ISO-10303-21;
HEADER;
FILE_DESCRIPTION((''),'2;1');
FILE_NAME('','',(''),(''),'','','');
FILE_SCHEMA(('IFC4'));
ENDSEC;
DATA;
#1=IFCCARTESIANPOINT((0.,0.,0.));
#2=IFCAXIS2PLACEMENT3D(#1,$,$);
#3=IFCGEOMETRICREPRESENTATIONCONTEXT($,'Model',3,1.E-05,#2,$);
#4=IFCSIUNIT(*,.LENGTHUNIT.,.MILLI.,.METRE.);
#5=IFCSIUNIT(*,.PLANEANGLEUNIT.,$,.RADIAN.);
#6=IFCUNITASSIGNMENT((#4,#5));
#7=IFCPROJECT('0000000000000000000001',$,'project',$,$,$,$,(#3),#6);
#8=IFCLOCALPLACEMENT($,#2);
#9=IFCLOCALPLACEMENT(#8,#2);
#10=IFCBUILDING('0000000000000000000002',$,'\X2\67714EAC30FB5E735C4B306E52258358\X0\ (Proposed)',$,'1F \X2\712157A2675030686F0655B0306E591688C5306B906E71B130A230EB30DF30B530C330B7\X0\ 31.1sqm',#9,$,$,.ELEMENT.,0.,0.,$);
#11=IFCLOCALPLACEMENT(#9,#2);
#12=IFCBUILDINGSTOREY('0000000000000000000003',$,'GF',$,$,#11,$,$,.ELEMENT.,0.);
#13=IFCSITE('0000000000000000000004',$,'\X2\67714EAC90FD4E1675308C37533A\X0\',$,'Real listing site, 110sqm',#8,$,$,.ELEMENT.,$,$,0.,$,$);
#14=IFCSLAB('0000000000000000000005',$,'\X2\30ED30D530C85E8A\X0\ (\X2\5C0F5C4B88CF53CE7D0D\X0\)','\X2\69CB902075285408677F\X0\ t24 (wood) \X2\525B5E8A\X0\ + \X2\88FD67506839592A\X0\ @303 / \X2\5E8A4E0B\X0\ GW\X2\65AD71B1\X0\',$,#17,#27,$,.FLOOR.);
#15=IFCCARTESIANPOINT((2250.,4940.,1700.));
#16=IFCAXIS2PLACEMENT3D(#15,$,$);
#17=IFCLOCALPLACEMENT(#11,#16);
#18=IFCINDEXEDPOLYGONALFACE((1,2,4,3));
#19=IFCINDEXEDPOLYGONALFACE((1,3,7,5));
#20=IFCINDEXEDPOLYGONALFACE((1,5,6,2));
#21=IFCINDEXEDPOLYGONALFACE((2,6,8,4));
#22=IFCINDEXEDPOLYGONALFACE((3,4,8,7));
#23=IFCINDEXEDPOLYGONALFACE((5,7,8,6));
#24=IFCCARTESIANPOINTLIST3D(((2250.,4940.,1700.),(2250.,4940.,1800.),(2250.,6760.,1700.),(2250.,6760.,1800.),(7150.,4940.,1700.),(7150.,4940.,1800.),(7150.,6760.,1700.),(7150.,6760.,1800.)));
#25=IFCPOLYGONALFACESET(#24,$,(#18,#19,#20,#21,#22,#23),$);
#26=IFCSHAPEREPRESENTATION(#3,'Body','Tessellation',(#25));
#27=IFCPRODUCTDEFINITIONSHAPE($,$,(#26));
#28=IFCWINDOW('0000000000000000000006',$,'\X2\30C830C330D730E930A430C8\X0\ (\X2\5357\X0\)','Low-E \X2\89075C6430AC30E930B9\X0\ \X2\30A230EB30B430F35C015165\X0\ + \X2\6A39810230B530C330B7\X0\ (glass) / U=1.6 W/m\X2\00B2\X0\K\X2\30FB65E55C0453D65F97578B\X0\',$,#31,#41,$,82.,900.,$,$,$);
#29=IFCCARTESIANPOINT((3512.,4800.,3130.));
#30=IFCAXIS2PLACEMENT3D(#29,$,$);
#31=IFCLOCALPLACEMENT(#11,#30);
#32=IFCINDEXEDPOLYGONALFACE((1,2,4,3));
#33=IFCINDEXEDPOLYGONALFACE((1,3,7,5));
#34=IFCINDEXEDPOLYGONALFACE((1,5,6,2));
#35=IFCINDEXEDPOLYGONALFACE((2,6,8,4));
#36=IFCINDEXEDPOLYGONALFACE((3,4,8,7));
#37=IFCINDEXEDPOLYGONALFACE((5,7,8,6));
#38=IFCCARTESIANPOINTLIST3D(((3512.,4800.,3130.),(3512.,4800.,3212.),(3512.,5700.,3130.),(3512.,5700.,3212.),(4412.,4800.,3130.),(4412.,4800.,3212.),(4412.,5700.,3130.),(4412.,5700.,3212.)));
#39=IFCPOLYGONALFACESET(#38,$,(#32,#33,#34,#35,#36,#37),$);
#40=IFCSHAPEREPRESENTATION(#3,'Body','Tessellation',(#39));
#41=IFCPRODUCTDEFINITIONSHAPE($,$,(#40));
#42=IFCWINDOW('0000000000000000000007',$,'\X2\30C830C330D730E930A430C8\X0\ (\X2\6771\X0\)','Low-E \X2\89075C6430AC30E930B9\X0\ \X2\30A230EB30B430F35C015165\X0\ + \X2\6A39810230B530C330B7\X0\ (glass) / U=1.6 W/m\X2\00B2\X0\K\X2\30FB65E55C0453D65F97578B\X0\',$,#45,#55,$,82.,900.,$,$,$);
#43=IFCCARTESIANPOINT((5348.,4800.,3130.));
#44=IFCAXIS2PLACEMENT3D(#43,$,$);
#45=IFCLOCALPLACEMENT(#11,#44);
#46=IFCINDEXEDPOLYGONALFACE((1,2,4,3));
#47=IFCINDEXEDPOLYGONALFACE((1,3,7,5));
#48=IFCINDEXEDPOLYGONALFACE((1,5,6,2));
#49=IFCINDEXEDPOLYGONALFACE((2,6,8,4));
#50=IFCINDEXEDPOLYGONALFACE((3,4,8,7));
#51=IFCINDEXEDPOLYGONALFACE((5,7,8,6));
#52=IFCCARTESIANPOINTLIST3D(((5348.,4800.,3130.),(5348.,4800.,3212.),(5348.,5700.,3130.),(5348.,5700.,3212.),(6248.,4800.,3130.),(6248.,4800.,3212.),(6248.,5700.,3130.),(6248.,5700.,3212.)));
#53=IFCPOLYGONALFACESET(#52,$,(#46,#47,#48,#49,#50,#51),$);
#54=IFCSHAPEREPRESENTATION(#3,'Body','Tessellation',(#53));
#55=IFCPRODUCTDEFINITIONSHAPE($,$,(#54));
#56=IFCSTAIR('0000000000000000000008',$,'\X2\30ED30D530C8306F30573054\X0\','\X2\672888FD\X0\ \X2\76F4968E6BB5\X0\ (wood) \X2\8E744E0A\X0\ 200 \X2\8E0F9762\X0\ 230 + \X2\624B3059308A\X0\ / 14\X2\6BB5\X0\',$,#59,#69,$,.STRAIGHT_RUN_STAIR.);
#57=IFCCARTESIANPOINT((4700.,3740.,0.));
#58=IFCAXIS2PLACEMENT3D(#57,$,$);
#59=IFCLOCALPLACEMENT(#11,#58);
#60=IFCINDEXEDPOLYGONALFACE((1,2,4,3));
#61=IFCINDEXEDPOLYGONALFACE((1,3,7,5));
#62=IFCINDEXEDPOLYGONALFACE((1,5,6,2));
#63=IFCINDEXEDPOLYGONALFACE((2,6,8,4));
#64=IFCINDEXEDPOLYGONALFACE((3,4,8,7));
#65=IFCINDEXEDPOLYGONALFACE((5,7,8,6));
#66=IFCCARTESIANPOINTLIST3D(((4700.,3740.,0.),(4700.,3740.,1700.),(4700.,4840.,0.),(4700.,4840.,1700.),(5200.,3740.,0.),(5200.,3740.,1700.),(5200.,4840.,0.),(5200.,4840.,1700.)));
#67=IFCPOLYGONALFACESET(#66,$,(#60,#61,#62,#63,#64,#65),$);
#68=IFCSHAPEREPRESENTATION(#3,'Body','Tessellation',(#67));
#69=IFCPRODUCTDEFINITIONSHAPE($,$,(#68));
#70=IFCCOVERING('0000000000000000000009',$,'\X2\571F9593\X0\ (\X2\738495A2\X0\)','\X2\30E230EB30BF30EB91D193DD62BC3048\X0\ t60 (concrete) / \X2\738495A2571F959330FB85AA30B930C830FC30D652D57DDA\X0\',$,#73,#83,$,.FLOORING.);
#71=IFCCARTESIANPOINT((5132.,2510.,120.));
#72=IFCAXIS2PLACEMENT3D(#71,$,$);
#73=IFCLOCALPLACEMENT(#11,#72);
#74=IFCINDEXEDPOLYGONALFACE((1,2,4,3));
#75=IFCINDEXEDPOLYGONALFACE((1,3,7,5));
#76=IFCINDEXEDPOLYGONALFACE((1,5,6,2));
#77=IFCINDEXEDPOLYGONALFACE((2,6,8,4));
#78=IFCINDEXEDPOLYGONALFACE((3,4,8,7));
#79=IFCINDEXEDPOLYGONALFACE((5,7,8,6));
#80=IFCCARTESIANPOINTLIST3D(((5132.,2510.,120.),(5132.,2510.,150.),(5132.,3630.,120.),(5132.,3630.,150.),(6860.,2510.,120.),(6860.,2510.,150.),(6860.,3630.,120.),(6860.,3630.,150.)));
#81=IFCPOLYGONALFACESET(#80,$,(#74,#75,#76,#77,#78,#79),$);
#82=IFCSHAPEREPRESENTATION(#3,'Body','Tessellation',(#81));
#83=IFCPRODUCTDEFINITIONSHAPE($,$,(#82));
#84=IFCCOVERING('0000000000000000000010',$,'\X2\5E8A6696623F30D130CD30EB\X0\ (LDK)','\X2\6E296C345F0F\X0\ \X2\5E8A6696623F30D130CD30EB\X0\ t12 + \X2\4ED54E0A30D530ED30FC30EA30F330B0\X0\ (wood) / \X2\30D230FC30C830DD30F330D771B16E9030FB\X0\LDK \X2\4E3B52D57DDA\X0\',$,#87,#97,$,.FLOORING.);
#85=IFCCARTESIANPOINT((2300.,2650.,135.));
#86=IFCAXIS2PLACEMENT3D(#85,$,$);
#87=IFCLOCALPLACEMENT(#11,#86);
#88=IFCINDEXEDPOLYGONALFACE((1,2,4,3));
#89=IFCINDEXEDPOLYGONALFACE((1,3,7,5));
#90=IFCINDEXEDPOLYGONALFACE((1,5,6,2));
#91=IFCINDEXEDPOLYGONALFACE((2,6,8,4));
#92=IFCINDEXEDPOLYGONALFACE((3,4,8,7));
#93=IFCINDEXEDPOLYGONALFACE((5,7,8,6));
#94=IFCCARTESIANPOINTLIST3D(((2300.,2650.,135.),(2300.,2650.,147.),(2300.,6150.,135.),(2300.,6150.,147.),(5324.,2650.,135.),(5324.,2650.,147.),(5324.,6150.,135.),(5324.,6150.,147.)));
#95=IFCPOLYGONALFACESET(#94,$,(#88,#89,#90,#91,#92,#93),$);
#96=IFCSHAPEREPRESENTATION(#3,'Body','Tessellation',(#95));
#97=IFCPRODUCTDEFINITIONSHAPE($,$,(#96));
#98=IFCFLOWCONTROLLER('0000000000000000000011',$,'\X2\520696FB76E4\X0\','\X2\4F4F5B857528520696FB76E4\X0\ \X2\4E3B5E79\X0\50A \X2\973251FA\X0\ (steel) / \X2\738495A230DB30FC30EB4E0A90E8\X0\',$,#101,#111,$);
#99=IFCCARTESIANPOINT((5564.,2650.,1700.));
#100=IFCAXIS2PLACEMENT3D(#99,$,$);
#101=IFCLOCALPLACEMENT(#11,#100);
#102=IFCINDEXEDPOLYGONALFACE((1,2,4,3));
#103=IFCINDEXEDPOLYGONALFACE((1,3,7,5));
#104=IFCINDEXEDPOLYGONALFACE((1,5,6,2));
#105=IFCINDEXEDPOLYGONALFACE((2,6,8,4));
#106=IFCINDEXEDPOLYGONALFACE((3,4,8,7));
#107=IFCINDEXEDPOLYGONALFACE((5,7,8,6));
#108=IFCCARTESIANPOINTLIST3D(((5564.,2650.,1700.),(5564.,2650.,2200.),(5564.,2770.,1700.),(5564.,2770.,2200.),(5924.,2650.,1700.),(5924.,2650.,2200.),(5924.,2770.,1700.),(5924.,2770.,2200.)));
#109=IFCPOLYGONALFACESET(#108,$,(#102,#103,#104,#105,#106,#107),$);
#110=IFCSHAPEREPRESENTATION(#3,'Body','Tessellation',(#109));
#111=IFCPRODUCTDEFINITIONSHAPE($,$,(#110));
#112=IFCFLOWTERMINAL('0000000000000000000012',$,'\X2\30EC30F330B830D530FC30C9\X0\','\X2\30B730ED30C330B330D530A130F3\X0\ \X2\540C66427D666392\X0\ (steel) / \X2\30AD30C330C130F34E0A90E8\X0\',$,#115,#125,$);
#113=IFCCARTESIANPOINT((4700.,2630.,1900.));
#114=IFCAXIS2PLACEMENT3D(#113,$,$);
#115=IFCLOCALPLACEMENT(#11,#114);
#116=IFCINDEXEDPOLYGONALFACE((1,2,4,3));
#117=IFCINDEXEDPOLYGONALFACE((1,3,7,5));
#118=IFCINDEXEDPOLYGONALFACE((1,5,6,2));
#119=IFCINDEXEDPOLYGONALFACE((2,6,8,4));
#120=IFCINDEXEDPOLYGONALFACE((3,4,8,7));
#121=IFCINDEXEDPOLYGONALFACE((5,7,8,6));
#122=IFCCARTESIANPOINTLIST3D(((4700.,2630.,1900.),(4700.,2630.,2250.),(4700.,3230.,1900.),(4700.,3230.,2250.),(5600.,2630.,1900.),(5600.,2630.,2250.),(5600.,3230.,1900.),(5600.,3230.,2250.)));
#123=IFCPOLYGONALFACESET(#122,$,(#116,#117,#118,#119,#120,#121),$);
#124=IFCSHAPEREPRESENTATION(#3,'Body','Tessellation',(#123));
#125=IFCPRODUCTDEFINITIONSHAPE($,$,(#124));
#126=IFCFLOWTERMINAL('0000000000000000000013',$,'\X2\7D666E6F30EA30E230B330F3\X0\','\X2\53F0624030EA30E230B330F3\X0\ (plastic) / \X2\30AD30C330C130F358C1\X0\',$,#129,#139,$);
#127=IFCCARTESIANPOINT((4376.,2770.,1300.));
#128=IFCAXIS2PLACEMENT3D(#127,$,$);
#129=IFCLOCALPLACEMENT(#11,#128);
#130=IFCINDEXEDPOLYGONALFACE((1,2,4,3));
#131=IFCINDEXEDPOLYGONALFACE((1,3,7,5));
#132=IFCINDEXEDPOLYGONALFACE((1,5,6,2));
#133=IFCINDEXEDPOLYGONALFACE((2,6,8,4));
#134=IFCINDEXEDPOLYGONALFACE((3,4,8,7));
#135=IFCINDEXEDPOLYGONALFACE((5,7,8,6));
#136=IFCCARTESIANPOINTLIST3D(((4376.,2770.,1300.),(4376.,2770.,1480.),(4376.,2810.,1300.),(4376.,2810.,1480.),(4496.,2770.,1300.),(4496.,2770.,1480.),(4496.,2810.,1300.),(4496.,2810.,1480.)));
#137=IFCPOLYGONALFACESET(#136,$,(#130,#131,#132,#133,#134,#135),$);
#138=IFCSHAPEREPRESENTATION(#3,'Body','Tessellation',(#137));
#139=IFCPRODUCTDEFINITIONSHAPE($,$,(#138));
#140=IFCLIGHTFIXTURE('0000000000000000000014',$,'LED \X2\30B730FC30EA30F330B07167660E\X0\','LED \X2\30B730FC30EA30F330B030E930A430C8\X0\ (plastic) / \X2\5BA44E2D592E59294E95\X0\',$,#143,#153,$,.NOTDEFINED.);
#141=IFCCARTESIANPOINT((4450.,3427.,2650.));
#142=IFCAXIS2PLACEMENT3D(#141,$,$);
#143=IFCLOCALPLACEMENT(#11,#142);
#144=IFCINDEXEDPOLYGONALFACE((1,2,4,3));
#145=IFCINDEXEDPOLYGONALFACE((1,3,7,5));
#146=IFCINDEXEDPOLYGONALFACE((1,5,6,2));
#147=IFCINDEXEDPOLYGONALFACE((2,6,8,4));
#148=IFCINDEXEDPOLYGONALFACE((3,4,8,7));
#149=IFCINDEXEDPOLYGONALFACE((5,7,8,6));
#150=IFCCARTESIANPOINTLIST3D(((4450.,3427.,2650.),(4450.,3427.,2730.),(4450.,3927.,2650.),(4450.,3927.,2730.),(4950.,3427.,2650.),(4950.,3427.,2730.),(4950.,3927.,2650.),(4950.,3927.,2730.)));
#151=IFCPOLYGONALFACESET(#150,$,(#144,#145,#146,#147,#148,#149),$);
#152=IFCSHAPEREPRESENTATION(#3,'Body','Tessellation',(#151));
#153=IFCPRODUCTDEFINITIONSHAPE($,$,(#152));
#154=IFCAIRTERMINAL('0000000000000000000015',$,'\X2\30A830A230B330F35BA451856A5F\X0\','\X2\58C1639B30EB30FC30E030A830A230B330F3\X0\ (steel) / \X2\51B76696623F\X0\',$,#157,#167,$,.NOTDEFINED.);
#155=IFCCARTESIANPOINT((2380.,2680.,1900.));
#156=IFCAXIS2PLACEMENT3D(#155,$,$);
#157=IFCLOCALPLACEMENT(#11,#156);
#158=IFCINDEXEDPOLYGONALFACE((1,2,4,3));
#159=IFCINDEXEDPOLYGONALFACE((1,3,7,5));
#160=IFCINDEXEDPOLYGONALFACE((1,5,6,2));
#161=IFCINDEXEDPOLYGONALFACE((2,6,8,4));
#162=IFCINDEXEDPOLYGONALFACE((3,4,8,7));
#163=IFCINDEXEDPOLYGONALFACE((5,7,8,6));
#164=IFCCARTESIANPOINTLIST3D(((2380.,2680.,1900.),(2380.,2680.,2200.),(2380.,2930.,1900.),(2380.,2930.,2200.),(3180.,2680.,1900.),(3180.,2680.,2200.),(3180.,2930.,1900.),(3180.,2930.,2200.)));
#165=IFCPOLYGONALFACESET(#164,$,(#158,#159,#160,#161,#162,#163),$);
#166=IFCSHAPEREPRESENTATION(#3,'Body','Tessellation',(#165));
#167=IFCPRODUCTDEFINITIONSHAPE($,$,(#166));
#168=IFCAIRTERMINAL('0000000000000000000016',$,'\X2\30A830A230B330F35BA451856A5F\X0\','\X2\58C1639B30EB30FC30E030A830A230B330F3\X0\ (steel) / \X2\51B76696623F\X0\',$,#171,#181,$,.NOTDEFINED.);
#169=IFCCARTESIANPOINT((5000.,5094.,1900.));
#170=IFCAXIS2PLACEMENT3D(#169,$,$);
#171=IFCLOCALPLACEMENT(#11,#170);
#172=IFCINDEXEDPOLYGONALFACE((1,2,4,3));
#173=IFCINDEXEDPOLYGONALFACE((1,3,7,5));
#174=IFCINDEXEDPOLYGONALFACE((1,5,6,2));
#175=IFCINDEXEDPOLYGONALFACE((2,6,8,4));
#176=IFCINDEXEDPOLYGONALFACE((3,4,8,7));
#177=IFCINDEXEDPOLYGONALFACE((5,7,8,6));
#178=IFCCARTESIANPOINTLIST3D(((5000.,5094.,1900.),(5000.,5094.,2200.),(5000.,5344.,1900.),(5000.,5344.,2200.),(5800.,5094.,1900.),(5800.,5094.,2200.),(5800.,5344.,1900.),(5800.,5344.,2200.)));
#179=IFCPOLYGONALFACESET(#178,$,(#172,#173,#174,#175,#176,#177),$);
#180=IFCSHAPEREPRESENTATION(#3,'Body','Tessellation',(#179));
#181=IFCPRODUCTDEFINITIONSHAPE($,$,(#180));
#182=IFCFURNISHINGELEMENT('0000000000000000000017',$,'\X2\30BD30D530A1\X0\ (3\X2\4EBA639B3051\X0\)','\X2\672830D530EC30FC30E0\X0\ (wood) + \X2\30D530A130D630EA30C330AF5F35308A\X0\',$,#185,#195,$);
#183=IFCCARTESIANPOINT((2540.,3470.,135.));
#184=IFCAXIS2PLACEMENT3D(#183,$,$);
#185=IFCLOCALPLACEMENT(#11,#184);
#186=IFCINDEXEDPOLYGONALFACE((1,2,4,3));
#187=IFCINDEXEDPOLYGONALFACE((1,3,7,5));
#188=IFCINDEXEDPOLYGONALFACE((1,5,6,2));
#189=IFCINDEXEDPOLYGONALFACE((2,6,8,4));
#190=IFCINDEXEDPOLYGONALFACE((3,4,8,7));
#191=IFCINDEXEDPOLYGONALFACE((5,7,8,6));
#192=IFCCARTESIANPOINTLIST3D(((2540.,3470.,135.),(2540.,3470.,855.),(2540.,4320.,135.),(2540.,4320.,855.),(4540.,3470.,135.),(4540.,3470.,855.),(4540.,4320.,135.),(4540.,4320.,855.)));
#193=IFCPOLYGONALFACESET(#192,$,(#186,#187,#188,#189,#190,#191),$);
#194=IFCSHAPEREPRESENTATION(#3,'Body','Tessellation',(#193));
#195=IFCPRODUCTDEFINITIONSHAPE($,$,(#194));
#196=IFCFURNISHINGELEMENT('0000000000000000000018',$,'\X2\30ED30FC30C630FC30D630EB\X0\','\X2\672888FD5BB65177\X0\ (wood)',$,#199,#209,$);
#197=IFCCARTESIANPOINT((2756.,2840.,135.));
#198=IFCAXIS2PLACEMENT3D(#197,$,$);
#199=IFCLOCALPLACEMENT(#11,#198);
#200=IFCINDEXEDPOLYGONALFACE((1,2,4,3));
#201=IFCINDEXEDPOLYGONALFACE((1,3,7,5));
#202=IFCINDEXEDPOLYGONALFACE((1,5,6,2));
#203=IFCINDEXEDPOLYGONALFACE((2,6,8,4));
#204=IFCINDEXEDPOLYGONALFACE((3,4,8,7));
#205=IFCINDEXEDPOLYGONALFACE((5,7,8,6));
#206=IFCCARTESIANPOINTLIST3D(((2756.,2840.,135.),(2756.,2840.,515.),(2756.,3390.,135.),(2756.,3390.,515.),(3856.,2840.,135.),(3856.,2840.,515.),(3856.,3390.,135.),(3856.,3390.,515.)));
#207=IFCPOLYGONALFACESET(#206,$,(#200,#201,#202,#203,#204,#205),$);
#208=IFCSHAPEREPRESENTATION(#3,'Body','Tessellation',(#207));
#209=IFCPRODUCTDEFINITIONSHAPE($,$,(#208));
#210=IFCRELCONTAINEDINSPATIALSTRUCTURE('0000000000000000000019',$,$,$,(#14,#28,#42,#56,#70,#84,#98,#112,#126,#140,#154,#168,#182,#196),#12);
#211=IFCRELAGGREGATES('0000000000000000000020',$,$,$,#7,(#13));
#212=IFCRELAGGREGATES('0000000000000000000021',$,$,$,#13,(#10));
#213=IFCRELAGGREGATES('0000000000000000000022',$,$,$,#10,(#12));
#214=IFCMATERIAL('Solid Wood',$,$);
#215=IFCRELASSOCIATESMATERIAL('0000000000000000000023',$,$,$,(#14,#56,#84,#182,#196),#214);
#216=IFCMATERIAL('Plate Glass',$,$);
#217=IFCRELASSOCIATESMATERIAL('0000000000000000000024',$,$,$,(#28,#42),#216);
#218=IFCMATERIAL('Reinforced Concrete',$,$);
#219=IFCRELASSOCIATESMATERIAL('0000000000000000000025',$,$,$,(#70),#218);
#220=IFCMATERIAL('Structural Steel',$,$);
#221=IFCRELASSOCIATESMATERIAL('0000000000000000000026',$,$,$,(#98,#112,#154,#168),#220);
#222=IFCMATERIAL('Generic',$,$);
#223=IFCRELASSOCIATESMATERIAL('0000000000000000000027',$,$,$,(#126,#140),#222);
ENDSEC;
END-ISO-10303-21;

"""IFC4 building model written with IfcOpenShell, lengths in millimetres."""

from ifc_helpers import new_model, si_unit, frame, frame_2d, origin, place, context, project, spatial, rectangle, extrude, material, element, save


model = new_model("IFC4")

# Units and contexts
model_context = context("Model", 3, precision=1e-05, world=origin())
ifc_project = project(units=[si_unit("LENGTHUNIT", "METRE", prefix="MILLI"), si_unit("PLANEANGLEUNIT", "RADIAN")], contexts=[model_context])

# Site, building, storey
site_placement = place(None, origin())
site = spatial("IfcSite", under=ifc_project, at=site_placement, Name="東京都世田谷区", ObjectType="Real listing site, 110sqm", CompositionType="ELEMENT", RefElevation=0.0)
building_placement = place(site_placement, origin())
building = spatial("IfcBuilding", under=site, at=building_placement, Name="東京・平屋の別荘 (Proposed)", ObjectType="1F 無垢材と漆喰の外装に遮熱アルミサッシ 31.1sqm", CompositionType="ELEMENT", ElevationOfRefHeight=0.0, ElevationOfTerrain=0.0)
storey_placement = place(building_placement, origin())
storey = spatial("IfcBuildingStorey", under=building, at=storey_placement, Name="GF", CompositionType="ELEMENT", Elevation=0.0)

# Shared definitions
ifc_material_1 = material(Name="Solid Wood")

# Slab
slab_placement = place(storey_placement, frame((2250.0, 4940.0, 1700.0)))
element("IfcSlab", 1, at=slab_placement, inside=storey, material=ifc_material_1, Name="ロフト床 (小屋裏収納)", Description="構造用合板 t24 (wood) 剛床 + 製材根太 @303 / 床下 GW断熱", PredefinedType="FLOOR", context=model_context, shape_type="SweptSolid", body=[
    extrude(rectangle(XDim=4900.0, YDim=1820.0, at=frame_2d((2450.0, 910.0))), frame((2250.0, 4940.0, 1700.0)), (0.0, 0.0, 1.0), 100.0),
])

# Windows
ifc_material_2 = material(Name="Plate Glass")
window_1_placement = place(storey_placement, frame((3512.0, 4800.0, 3130.0)))
element("IfcWindow", 2, at=window_1_placement, inside=storey, material=ifc_material_2, Name="トップライト (南)", Description="Low-E 複層ガラス アルゴン封入 + 樹脂サッシ (glass) / U=1.6 W/m²K・日射取得型", OverallHeight=82.0, OverallWidth=900.0, context=model_context, shape_type="SweptSolid", body=[
    extrude(rectangle(XDim=900.0, YDim=900.0, at=frame_2d((450.0, 450.0))), frame((3512.0, 4800.0, 3130.0)), (0.0, 0.0, 1.0), 82.0),
])
window_2_placement = place(storey_placement, frame((5348.0, 4800.0, 3130.0)))
element("IfcWindow", 3, at=window_2_placement, inside=storey, material=ifc_material_2, Name="トップライト (東)", Description="Low-E 複層ガラス アルゴン封入 + 樹脂サッシ (glass) / U=1.6 W/m²K・日射取得型", OverallHeight=82.0, OverallWidth=900.0, context=model_context, shape_type="SweptSolid", body=[
    extrude(rectangle(XDim=900.0, YDim=900.0, at=frame_2d((450.0, 450.0))), frame((5348.0, 4800.0, 3130.0)), (0.0, 0.0, 1.0), 82.0),
])

# Stair
stair_placement = place(storey_placement, frame((4700.0, 3740.0, 0.0)))
element("IfcStair", 4, at=stair_placement, inside=storey, material=ifc_material_1, Name="ロフトはしご", Description="木製 直階段 (wood) 蹴上 200 踏面 230 + 手すり / 14段", PredefinedType="STRAIGHT_RUN_STAIR", context=model_context, shape_type="SweptSolid", body=[
    extrude(rectangle(XDim=500.0, YDim=1100.0, at=frame_2d((250.0, 550.0))), frame((4700.0, 3740.0, 0.0)), (0.0, 0.0, 1.0), 1700.0),
])

# Coverings
ifc_material_3 = material(Name="Reinforced Concrete")
covering_1_placement = place(storey_placement, frame((5132.0, 2510.0, 120.0)))
element("IfcCovering", 5, at=covering_1_placement, inside=storey, material=ifc_material_3, Name="土間 (玄関)", Description="モルタル金鏝押え t60 (concrete) / 玄関土間・薪ストーブ動線", PredefinedType="FLOORING", context=model_context, shape_type="SweptSolid", body=[
    extrude(rectangle(XDim=1728.0, YDim=1120.0, at=frame_2d((864.0, 560.0))), frame((5132.0, 2510.0, 120.0)), (0.0, 0.0, 1.0), 30.0),
])
covering_2_placement = place(storey_placement, frame((2300.0, 2650.0, 135.0)))
element("IfcCovering", 6, at=covering_2_placement, inside=storey, material=ifc_material_1, Name="床暖房パネル (LDK)", Description="温水式 床暖房パネル t12 + 仕上フローリング (wood) / ヒートポンプ熱源・LDK 主動線", PredefinedType="FLOORING", context=model_context, shape_type="SweptSolid", body=[
    extrude(rectangle(XDim=3024.0, YDim=3500.0, at=frame_2d((1512.0, 1750.0))), frame((2300.0, 2650.0, 135.0)), (0.0, 0.0, 1.0), 12.0),
])

# Flow controller
ifc_material_4 = material(Name="Structural Steel")
flow_controller_placement = place(storey_placement, frame((5564.0, 2650.0, 1700.0)))
element("IfcFlowController", 7, at=flow_controller_placement, inside=storey, material=ifc_material_4, Name="分電盤", Description="住宅用分電盤 主幹50A 露出 (steel) / 玄関ホール上部", context=model_context, shape_type="SweptSolid", body=[
    extrude(rectangle(XDim=360.0, YDim=120.0, at=frame_2d((180.0, 60.0))), frame((5564.0, 2650.0, 1700.0)), (0.0, 0.0, 1.0), 500.0),
])

# Flow terminals
flow_terminal_1_placement = place(storey_placement, frame((4700.0, 2630.0, 1900.0)))
element("IfcFlowTerminal", 8, at=flow_terminal_1_placement, inside=storey, material=ifc_material_4, Name="レンジフード", Description="シロッコファン 同時給排 (steel) / キッチン上部", context=model_context, shape_type="SweptSolid", body=[
    extrude(rectangle(XDim=900.0, YDim=600.0, at=frame_2d((450.0, 300.0))), frame((4700.0, 2630.0, 1900.0)), (0.0, 0.0, 1.0), 350.0),
])
ifc_material_5 = material(Name="Generic")
flow_terminal_2_placement = place(storey_placement, frame((4376.0, 2770.0, 1300.0)))
element("IfcFlowTerminal", 9, at=flow_terminal_2_placement, inside=storey, material=ifc_material_5, Name="給湯リモコン", Description="台所リモコン (plastic) / キッチン壁", context=model_context, shape_type="SweptSolid", body=[
    extrude(rectangle(XDim=120.0, YDim=40.0, at=frame_2d((60.0, 20.0))), frame((4376.0, 2770.0, 1300.0)), (0.0, 0.0, 1.0), 180.0),
])

# Light fixture
light_fixture_placement = place(storey_placement, frame((4450.0, 3427.0, 2650.0)))
element("IfcLightFixture", 10, at=light_fixture_placement, inside=storey, material=ifc_material_5, Name="LED シーリング照明", Description="LED シーリングライト (plastic) / 室中央天井", PredefinedType="NOTDEFINED", context=model_context, shape_type="SweptSolid", body=[
    extrude(rectangle(XDim=500.0, YDim=500.0, at=frame_2d((250.0, 250.0))), frame((4450.0, 3427.0, 2650.0)), (0.0, 0.0, 1.0), 80.0),
])

# Air terminals
air_terminal_1_placement = place(storey_placement, frame((2380.0, 2680.0, 1900.0)))
element("IfcAirTerminal", 11, at=air_terminal_1_placement, inside=storey, material=ifc_material_4, Name="エアコン室内機", Description="壁掛ルームエアコン (steel) / 冷暖房", PredefinedType="NOTDEFINED", context=model_context, shape_type="SweptSolid", body=[
    extrude(rectangle(XDim=800.0, YDim=250.0, at=frame_2d((400.0, 125.0))), frame((2380.0, 2680.0, 1900.0)), (0.0, 0.0, 1.0), 300.0),
])
air_terminal_2_placement = place(storey_placement, frame((5000.0, 5094.0, 1900.0)))
element("IfcAirTerminal", 12, at=air_terminal_2_placement, inside=storey, material=ifc_material_4, Name="エアコン室内機", Description="壁掛ルームエアコン (steel) / 冷暖房", PredefinedType="NOTDEFINED", context=model_context, shape_type="SweptSolid", body=[
    extrude(rectangle(XDim=800.0, YDim=250.0, at=frame_2d((400.0, 125.0))), frame((5000.0, 5094.0, 1900.0)), (0.0, 0.0, 1.0), 300.0),
])

# Furnishing elements
furnishing_1_placement = place(storey_placement, frame((2540.0, 3470.0, 135.0)))
element("IfcFurnishingElement", 13, at=furnishing_1_placement, inside=storey, material=ifc_material_1, Name="ソファ (3人掛け)", Description="木フレーム (wood) + ファブリック張り", context=model_context, shape_type="SweptSolid", body=[
    extrude(rectangle(XDim=2000.0, YDim=850.0, at=frame_2d((1000.0, 425.0))), frame((2540.0, 3470.0, 135.0)), (0.0, 0.0, 1.0), 720.0),
])
furnishing_2_placement = place(storey_placement, frame((2756.0, 2840.0, 135.0)))
element("IfcFurnishingElement", 14, at=furnishing_2_placement, inside=storey, material=ifc_material_1, Name="ローテーブル", Description="木製家具 (wood)", context=model_context, shape_type="SweptSolid", body=[
    extrude(rectangle(XDim=1100.0, YDim=550.0, at=frame_2d((550.0, 275.0))), frame((2756.0, 2840.0, 135.0)), (0.0, 0.0, 1.0), 380.0),
])

save(model, "model.ifc")
